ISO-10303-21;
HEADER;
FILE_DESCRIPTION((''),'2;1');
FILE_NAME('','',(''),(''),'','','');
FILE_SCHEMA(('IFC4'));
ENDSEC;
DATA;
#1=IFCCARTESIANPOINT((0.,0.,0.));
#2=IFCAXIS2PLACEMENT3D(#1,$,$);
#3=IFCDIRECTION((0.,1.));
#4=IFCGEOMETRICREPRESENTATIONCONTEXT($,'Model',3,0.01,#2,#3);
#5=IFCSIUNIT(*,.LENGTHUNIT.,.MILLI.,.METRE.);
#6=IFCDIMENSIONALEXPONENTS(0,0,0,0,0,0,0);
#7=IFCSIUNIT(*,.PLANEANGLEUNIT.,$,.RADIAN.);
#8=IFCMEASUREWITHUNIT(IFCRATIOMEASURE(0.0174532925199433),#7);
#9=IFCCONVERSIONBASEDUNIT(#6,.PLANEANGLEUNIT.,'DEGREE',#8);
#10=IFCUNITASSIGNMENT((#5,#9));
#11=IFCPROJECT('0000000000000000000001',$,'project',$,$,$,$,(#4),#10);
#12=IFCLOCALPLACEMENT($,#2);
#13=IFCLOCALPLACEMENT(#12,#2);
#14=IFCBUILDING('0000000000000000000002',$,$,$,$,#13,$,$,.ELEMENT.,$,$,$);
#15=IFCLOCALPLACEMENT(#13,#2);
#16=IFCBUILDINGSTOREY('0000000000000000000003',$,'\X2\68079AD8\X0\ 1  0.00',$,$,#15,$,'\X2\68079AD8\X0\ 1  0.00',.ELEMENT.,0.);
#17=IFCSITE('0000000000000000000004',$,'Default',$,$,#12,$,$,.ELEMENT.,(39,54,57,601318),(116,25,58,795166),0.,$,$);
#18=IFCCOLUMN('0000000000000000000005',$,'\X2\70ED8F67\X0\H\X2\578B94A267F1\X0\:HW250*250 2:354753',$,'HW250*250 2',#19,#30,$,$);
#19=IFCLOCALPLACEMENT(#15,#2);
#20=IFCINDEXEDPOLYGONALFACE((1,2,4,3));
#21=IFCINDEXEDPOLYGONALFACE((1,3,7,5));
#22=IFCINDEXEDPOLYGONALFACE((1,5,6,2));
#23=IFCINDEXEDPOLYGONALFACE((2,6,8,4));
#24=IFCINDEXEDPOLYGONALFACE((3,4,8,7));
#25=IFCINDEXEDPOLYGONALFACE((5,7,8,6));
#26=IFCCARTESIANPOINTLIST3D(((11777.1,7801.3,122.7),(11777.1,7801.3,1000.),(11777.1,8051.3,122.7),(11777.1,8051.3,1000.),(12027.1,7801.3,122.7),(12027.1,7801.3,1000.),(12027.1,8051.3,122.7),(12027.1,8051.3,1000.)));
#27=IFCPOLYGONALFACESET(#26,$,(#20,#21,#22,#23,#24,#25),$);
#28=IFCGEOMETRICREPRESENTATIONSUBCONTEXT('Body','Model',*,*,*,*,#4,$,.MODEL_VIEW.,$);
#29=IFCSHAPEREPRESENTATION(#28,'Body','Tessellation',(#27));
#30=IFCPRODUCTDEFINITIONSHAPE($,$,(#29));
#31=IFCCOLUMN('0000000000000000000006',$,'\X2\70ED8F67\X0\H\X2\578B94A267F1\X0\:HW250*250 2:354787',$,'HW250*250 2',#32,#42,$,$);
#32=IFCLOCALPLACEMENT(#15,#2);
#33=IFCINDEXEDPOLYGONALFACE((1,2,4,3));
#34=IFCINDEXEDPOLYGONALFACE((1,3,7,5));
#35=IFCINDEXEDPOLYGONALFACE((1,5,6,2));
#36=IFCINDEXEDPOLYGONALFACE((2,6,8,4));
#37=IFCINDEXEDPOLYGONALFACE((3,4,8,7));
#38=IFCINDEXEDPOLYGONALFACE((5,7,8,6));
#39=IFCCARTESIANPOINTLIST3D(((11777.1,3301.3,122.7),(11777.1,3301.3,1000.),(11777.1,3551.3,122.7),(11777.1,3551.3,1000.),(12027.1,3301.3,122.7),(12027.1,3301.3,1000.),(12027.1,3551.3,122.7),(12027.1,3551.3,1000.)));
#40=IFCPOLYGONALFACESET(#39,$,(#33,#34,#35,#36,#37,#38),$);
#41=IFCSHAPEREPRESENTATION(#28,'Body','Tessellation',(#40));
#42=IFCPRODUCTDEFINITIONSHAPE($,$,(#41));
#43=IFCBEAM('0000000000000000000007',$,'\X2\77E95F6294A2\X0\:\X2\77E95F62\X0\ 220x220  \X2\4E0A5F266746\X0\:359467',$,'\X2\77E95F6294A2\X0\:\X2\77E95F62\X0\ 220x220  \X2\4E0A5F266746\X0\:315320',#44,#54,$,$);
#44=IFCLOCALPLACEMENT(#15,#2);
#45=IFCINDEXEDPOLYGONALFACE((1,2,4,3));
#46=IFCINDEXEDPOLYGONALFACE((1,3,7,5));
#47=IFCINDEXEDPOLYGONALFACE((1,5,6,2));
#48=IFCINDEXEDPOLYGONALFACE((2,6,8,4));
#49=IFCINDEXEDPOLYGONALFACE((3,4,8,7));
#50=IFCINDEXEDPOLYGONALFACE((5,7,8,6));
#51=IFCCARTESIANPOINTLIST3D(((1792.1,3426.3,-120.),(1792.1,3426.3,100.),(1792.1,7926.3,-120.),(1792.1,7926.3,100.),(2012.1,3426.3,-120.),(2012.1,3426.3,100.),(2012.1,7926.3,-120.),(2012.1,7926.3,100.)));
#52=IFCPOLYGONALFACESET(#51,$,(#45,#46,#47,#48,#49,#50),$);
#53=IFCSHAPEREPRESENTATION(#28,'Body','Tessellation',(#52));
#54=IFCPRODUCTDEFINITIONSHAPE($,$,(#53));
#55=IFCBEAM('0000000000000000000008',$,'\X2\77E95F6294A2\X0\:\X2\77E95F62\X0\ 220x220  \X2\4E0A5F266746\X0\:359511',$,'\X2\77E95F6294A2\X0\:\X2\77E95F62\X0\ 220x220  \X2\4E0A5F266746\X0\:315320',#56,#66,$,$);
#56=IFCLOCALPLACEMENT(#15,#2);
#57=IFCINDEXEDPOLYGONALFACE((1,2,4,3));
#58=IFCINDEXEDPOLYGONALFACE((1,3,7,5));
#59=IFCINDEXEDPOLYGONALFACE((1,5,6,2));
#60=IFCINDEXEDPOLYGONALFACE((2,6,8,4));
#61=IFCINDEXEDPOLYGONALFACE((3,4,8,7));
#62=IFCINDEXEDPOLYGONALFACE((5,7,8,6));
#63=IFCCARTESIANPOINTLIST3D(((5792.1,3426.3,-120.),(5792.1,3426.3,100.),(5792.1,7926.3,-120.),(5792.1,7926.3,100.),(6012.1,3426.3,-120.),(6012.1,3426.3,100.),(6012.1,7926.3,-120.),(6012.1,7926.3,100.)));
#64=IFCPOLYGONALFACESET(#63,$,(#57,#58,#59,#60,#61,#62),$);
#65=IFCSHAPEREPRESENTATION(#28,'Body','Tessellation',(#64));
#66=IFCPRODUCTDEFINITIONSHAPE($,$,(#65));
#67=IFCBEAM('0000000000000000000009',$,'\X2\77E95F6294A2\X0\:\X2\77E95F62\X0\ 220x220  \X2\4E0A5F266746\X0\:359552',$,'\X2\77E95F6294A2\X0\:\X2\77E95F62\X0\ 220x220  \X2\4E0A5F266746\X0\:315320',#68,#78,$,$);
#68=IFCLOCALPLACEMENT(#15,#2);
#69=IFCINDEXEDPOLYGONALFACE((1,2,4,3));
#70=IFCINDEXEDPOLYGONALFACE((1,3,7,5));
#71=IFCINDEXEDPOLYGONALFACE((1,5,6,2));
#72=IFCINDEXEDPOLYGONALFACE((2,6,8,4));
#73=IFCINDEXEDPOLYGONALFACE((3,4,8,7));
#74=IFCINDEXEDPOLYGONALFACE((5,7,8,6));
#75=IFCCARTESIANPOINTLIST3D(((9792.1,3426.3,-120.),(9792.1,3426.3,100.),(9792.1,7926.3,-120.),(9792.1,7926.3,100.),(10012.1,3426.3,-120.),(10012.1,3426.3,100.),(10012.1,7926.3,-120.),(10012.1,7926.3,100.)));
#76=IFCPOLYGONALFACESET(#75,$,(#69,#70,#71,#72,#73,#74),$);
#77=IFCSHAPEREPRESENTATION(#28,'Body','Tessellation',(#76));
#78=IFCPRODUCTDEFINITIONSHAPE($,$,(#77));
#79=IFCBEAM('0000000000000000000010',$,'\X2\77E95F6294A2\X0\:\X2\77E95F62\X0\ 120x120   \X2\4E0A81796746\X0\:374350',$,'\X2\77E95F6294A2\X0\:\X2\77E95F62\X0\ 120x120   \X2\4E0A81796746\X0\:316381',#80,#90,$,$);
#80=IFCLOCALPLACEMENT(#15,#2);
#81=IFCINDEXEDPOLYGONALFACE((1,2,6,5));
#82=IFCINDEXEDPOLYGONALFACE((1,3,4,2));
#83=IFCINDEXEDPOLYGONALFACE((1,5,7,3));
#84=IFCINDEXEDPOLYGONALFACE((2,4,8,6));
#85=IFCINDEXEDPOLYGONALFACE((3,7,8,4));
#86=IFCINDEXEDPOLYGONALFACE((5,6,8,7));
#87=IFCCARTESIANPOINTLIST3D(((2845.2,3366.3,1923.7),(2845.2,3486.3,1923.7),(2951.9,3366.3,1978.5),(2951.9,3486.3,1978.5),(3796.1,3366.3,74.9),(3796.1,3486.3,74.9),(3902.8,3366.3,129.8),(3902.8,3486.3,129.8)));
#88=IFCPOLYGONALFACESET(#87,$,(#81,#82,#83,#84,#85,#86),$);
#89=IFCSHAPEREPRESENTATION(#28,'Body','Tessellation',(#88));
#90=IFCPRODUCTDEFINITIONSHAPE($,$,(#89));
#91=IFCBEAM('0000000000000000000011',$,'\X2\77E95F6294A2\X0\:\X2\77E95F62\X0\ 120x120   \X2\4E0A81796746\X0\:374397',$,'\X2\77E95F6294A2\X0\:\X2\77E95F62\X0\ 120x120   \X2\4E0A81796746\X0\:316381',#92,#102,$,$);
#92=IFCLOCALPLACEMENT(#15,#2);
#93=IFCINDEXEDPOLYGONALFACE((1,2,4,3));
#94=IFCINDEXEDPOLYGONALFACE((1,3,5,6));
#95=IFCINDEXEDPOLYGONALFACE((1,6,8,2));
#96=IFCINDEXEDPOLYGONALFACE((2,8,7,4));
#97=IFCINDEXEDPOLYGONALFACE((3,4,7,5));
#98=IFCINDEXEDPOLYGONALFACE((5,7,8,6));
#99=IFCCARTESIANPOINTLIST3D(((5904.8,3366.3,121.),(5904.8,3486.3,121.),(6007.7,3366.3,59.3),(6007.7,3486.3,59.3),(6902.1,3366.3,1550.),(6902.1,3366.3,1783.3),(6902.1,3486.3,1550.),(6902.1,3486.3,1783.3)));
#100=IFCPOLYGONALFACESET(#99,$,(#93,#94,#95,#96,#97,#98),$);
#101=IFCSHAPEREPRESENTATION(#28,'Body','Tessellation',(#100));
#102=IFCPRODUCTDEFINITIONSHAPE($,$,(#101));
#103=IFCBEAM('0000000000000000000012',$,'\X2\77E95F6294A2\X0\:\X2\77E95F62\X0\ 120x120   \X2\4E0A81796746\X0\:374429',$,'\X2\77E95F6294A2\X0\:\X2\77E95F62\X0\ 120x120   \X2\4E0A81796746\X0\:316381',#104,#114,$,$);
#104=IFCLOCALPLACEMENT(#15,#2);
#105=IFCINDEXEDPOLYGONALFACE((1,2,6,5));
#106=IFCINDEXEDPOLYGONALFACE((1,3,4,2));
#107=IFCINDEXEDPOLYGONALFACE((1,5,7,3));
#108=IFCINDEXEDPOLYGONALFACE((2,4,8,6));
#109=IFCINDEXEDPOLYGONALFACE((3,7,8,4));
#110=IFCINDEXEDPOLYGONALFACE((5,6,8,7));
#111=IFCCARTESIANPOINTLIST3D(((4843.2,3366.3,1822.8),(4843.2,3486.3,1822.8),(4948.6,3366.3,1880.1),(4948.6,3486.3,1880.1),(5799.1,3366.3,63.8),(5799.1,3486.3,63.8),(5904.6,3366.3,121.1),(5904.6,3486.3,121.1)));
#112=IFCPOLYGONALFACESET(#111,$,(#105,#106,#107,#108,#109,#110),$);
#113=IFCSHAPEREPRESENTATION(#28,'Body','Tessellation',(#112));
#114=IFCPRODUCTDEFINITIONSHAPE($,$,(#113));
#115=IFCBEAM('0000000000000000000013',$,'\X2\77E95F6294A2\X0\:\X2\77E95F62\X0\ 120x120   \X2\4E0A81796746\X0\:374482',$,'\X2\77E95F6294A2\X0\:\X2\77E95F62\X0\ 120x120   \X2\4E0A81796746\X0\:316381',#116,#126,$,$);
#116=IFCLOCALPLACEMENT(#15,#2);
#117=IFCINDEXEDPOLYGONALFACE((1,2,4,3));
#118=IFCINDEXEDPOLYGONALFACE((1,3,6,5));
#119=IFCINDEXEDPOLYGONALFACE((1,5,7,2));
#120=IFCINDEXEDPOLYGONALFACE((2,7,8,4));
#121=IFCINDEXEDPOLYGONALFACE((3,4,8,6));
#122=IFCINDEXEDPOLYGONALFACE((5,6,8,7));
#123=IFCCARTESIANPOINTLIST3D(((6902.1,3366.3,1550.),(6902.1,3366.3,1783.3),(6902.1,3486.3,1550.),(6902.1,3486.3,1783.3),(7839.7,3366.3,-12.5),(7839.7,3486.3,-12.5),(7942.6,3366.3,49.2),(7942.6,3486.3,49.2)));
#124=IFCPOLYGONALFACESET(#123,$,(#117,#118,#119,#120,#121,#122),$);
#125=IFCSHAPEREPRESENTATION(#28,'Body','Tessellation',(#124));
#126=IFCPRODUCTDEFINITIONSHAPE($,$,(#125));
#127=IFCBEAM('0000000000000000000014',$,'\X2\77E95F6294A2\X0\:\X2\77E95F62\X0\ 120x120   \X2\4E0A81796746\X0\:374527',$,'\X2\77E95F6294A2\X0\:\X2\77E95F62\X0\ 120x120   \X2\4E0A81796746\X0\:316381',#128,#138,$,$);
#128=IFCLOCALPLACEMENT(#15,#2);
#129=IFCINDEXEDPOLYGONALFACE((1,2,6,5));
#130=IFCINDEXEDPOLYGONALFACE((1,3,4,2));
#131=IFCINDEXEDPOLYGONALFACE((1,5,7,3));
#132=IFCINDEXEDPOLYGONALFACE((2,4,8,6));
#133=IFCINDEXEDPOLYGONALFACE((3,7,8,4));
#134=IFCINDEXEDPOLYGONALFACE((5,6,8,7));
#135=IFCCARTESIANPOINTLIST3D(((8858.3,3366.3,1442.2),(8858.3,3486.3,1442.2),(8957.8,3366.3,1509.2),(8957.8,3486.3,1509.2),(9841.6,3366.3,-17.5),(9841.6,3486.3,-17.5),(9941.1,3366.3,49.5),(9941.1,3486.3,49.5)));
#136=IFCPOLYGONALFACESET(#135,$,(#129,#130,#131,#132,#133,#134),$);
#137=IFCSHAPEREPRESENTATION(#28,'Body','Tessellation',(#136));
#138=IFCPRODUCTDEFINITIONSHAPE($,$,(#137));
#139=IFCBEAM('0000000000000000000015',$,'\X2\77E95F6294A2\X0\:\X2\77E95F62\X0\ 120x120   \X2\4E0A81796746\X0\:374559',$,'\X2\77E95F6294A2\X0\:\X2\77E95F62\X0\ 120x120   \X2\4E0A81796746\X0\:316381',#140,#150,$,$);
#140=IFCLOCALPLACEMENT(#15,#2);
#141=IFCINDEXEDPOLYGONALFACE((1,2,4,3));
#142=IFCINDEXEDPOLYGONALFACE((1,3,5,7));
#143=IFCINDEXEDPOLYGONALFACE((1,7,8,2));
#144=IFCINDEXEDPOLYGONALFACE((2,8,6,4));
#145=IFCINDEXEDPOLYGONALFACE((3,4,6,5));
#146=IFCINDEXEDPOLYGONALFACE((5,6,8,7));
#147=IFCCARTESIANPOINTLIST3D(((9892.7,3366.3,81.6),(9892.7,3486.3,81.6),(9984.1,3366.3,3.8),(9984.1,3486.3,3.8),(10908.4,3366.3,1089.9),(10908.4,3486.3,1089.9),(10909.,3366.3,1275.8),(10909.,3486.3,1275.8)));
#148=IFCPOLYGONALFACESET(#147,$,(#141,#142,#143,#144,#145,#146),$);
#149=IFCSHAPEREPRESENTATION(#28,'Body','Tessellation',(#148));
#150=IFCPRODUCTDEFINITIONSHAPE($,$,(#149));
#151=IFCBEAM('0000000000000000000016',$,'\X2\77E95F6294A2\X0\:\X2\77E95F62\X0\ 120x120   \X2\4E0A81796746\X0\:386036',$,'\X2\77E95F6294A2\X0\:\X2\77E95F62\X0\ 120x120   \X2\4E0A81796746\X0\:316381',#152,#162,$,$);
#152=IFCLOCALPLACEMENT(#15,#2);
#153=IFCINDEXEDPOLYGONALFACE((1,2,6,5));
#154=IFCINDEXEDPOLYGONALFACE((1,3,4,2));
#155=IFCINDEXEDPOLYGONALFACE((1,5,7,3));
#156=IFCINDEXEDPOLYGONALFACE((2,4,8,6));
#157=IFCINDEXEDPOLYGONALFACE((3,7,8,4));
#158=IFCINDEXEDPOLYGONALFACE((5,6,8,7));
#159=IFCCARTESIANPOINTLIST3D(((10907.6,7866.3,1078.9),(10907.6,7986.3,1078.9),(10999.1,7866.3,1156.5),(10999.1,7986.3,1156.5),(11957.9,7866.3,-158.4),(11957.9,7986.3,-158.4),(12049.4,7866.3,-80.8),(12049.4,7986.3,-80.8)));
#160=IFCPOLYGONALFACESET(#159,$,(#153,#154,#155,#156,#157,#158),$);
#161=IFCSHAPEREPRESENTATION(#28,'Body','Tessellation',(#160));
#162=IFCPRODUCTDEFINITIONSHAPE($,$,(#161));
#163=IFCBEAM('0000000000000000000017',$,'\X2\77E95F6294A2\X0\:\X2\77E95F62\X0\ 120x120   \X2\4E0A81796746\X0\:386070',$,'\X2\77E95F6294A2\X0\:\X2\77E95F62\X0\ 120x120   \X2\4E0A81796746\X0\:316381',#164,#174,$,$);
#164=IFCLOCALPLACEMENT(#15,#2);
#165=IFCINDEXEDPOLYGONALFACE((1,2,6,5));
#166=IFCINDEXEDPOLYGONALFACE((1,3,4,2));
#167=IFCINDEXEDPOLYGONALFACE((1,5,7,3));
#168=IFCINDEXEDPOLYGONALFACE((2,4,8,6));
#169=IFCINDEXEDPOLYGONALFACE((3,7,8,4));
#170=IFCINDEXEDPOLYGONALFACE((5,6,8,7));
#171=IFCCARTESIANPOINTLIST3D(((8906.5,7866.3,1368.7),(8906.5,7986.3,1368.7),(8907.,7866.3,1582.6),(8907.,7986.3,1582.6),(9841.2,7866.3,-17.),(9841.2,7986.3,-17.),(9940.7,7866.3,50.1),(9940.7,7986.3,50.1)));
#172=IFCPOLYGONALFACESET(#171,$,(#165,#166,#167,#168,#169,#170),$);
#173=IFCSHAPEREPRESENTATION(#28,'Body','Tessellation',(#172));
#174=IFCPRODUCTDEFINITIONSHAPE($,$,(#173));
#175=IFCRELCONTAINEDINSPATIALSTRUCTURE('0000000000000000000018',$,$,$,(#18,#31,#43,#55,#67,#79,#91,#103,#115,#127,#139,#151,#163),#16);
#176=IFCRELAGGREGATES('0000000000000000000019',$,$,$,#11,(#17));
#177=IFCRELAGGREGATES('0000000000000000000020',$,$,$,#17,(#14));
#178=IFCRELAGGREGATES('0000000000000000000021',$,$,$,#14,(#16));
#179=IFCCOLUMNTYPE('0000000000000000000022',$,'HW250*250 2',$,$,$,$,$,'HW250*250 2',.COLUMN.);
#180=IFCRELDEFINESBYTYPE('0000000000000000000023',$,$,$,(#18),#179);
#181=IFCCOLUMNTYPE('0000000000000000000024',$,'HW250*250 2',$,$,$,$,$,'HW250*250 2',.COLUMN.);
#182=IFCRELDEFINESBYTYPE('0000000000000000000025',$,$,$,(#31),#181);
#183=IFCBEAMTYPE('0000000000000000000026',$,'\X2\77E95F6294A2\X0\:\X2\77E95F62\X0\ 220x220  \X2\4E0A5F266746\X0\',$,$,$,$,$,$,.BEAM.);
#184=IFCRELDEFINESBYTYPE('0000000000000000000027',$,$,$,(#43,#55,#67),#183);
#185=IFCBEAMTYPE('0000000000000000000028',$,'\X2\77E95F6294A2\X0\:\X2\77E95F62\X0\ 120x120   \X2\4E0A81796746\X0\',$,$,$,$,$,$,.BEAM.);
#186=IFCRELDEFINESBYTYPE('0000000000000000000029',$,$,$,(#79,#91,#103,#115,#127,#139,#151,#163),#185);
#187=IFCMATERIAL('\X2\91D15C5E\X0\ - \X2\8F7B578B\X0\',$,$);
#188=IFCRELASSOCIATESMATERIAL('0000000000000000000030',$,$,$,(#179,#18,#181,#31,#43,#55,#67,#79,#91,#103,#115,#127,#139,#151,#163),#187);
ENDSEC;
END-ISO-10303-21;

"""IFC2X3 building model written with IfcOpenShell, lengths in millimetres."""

from ifc_helpers import new_model, entity, si_unit, converted_unit, direction, frame, frame_2d, origin, origin_2d_with_axis, place, context, subcontext, project, spatial, rectangle, extrude, clip, halfspace, source, transform, mapped, material, type_object, type_shapes, element, save


model = new_model("IFC2X3")

# Units and contexts
model_context = context("Model", 3, precision=0.01, world=origin(), true_north=direction((0.0, 1.0)))
body_context = subcontext(model_context, "Body", "Model", "MODEL_VIEW")
ifc_project = project(units=[si_unit("LENGTHUNIT", "METRE", prefix="MILLI"), converted_unit("PLANEANGLEUNIT", "DEGREE", entity("IfcRatioMeasure", 0.0174532925199433), si_unit("PLANEANGLEUNIT", "RADIAN"), dimensions=[0, 0, 0, 0, 0, 0, 0])], contexts=[model_context])

# Site, building, storey
site_placement = place(None, origin())
site = spatial("IfcSite", under=ifc_project, at=site_placement, Name="Default", CompositionType="ELEMENT", RefLatitude=(39, 54, 57, 601318), RefLongitude=(116, 25, 58, 795166), RefElevation=0.0)
building_placement = place(site_placement, origin())
building = spatial("IfcBuilding", under=site, at=building_placement, CompositionType="ELEMENT")
storey_placement = place(building_placement, origin())
storey = spatial("IfcBuildingStorey", under=building, at=storey_placement, Name="标高 1  0.00", LongName="标高 1  0.00", CompositionType="ELEMENT", Elevation=0.0)

# Columns
ifc_material_1 = material(Name="金属 - 轻型")
column_type_1 = type_object("IfcColumnType", Name="HW250*250 2", ElementType="HW250*250 2", PredefinedType="COLUMN", material=ifc_material_1)
shared_shape_1 = source(origin(), body_context, "Body", "SweptSolid", [
    extrude(rectangle(XDim=250.0, YDim=250.0, at=origin_2d_with_axis()), frame((11902.1, 7926.3, 122.7), z_axis=(0.0, 0.0, 1.0), x_axis=(0.0, -1.0, 0.0)), (0.0, 0.0, 1.0), 877.3),
])
type_shapes(column_type_1, [shared_shape_1])
column_1_placement = place(storey_placement, origin())
element("IfcColumn", 1, at=column_1_placement, inside=storey, type_object=column_type_1, material=ifc_material_1, Name="热轧H型钢柱:HW250*250 2:354753", ObjectType="HW250*250 2", context=body_context, shape_type="MappedRepresentation", body=[
    mapped(shared_shape_1, transform((0.0, 0.0, 0.0), scale=1.0)),
])
column_type_2 = type_object("IfcColumnType", Name="HW250*250 2", ElementType="HW250*250 2", PredefinedType="COLUMN", material=ifc_material_1)
shared_shape_2 = source(origin(), body_context, "Body", "SweptSolid", [
    extrude(rectangle(XDim=250.0, YDim=250.0, at=frame_2d((0.0, 0.0), x_axis=(1.0, 0.0))), frame((11902.1, 3426.3, 122.7), z_axis=(0.0, 0.0, 1.0), x_axis=(0.0, -1.0, 0.0)), (0.0, 0.0, 1.0), 877.3),
])
type_shapes(column_type_2, [shared_shape_2])
column_2_placement = place(storey_placement, origin())
element("IfcColumn", 2, at=column_2_placement, inside=storey, type_object=column_type_2, material=ifc_material_1, Name="热轧H型钢柱:HW250*250 2:354787", ObjectType="HW250*250 2", context=body_context, shape_type="MappedRepresentation", body=[
    mapped(shared_shape_2, transform((0.0, 0.0, 0.0), scale=1.0)),
])

# Beams
beam_type_1 = type_object("IfcBeamType", Name="矩形钢:矩形 220x220  上弦杆", PredefinedType="BEAM")
beam_1_placement = place(storey_placement, frame((1902.1, 7926.3, -10.0), z_axis=(0.0, 0.0, 1.0), x_axis=(0.0, -1.0, 0.0)))
element("IfcBeam", 3, at=beam_1_placement, inside=storey, type_object=beam_type_1, material=ifc_material_1, Name="矩形钢:矩形 220x220  上弦杆:359467", ObjectType="矩形钢:矩形 220x220  上弦杆:315320", context=body_context, shape_type="SweptSolid", body=[
    extrude(rectangle(XDim=220.0, YDim=220.0, at=origin_2d_with_axis()), frame((0.0, 0.0, 0.0), z_axis=(1.0, 0.0, 0.0), x_axis=(0.0, 0.0, -1.0)), (0.0, 0.0, 1.0), 4500.0),
])
beam_2_placement = place(storey_placement, frame((5902.1, 7926.3, -10.0), z_axis=(0.0, 0.0, 1.0), x_axis=(0.0, -1.0, 0.0)))
element("IfcBeam", 4, at=beam_2_placement, inside=storey, type_object=beam_type_1, material=ifc_material_1, Name="矩形钢:矩形 220x220  上弦杆:359511", ObjectType="矩形钢:矩形 220x220  上弦杆:315320", context=body_context, shape_type="SweptSolid", body=[
    extrude(rectangle(XDim=220.0, YDim=220.0, at=frame_2d((0.0, 0.0), x_axis=(1.0, 0.0))), frame((0.0, 0.0, 0.0), z_axis=(1.0, 0.0, 0.0), x_axis=(0.0, 0.0, -1.0)), (0.0, 0.0, 1.0), 4500.0),
])
beam_3_placement = place(storey_placement, frame((9902.1, 7926.3, -10.0), z_axis=(0.0, 0.0, 1.0), x_axis=(0.0, -1.0, 0.0)))
element("IfcBeam", 5, at=beam_3_placement, inside=storey, type_object=beam_type_1, material=ifc_material_1, Name="矩形钢:矩形 220x220  上弦杆:359552", ObjectType="矩形钢:矩形 220x220  上弦杆:315320", context=body_context, shape_type="SweptSolid", body=[
    extrude(rectangle(XDim=220.0, YDim=220.0, at=frame_2d((0.0, 0.0), x_axis=(1.0, 0.0))), frame((0.0, 0.0, 0.0), z_axis=(1.0, 0.0, 0.0), x_axis=(0.0, 0.0, -1.0)), (0.0, 0.0, 1.0), 4500.0),
])
beam_type_2 = type_object("IfcBeamType", Name="矩形钢:矩形 120x120   上腹杆", PredefinedType="BEAM")
beam_4_placement = place(storey_placement, frame((3902.1, 3426.3, 0.0), z_axis=(0.889261, 0.0, 0.457401), x_axis=(-0.457401, 0.0, 0.889261)))
element("IfcBeam", 6, at=beam_4_placement, inside=storey, type_object=beam_type_2, material=ifc_material_1, Name="矩形钢:矩形 120x120   上腹杆:374350", ObjectType="矩形钢:矩形 120x120   上腹杆:316381", context=body_context, shape_type="SweptSolid", body=[
    extrude(rectangle(XDim=120.0, YDim=120.0, at=frame_2d((0.0, 0.0), x_axis=(1.0, 0.0))), frame((115.1, 0.0, 0.0), z_axis=(1.0, 0.0, 0.0), x_axis=(0.0, 0.0, -1.0)), (0.0, 0.0, 1.0), 2079.0),
])
beam_5_placement = place(storey_placement, frame((5902.1, 3426.3, 0.0), z_axis=(0.857493, 0.0, -0.514496), x_axis=(0.514496, 0.0, 0.857493)))
element("IfcBeam", 7, at=beam_5_placement, inside=storey, type_object=beam_type_2, material=ifc_material_1, Name="矩形钢:矩形 120x120   上腹杆:374397", ObjectType="矩形钢:矩形 120x120   上腹杆:316381", context=body_context, shape_type="Clipping", body=[
    clip(extrude(rectangle(XDim=120.0, YDim=120.0, at=frame_2d((0.0, 0.0), x_axis=(1.0, 0.0))), frame((105.2, 0.0, 0.0), z_axis=(1.0, 0.0, 0.0), x_axis=(0.0, 0.0, -1.0)), (0.0, 0.0, 1.0), 1938.5), halfspace(frame((1843.7, 0.0, 60.0), z_axis=(0.514496, 0.0, 0.857493), x_axis=(0.0, 1.0, 0.0)), False)),
])
beam_6_placement = place(storey_placement, frame((5902.1, 3426.3, 0.0), z_axis=(0.87863, 0.0, 0.477502), x_axis=(-0.477502, 0.0, 0.87863)))
element("IfcBeam", 8, at=beam_6_placement, inside=storey, type_object=beam_type_2, material=ifc_material_1, Name="矩形钢:矩形 120x120   上腹杆:374429", ObjectType="矩形钢:矩形 120x120   上腹杆:316381", context=body_context, shape_type="SweptSolid", body=[
    extrude(rectangle(XDim=120.0, YDim=120.0, at=frame_2d((0.0, 0.0), x_axis=(1.0, 0.0))), frame((105.3, 0.0, 0.0), z_axis=(1.0, 0.0, 0.0), x_axis=(0.0, 0.0, -1.0)), (0.0, 0.0, 1.0), 2002.0),
])
beam_7_placement = place(storey_placement, frame((7902.1, 3426.3, 0.0), z_axis=(0.857493, 0.0, 0.514496), x_axis=(-0.514496, 0.0, 0.857493)))
element("IfcBeam", 9, at=beam_7_placement, inside=storey, type_object=beam_type_2, material=ifc_material_1, Name="矩形钢:矩形 120x120   上腹杆:374482", ObjectType="矩形钢:矩形 120x120   上腹杆:316381", context=body_context, shape_type="Clipping", body=[
    clip(extrude(rectangle(XDim=120.0, YDim=120.0, at=frame_2d((0.0, 0.0), x_axis=(1.0, 0.0))), frame((21.4, 0.0, 0.0), z_axis=(1.0, 0.0, 0.0), x_axis=(0.0, 0.0, -1.0)), (0.0, 0.0, 1.0), 2022.3), halfspace(frame((1843.7, 0.0, -60.0), z_axis=(0.514496, 0.0, -0.857493), x_axis=(0.0, -1.0, 0.0)), False)),
])
beam_8_placement = place(storey_placement, frame((9902.1, 3426.3, 0.0), z_axis=(0.829376, 0.0, 0.55869), x_axis=(-0.55869, 0.0, 0.829376)))
element("IfcBeam", 10, at=beam_8_placement, inside=storey, type_object=beam_type_2, material=ifc_material_1, Name="矩形钢:矩形 120x120   上腹杆:374527", ObjectType="矩形钢:矩形 120x120   上腹杆:316381", context=body_context, shape_type="SweptSolid", body=[
    extrude(rectangle(XDim=120.0, YDim=120.0, at=origin_2d_with_axis()), frame((19.3, 0.0, 0.0), z_axis=(1.0, 0.0, 0.0), x_axis=(0.0, 0.0, -1.0)), (0.0, 0.0, 1.0), 1760.0),
])
beam_9_placement = place(storey_placement, frame((10908.6, 3426.3, 1182.8), z_axis=(0.761584, 0.0, -0.648066), x_axis=(-0.648066, 0.0, -0.761584)))
element("IfcBeam", 11, at=beam_9_placement, inside=storey, type_object=beam_type_2, material=ifc_material_1, Name="矩形钢:矩形 120x120   上腹杆:374559", ObjectType="矩形钢:矩形 120x120   上腹杆:316381", context=body_context, shape_type="Clipping", body=[
    clip(extrude(rectangle(XDim=120.0, YDim=120.0, at=frame_2d((0.0, 0.0), x_axis=(1.0, 0.0))), frame((-71.1, 0.0, 0.0), z_axis=(1.0, 0.0, 0.0), x_axis=(0.0, 0.0, -1.0)), (0.0, 0.0, 1.0), 1568.1), halfspace(frame((-71.1, 0.0, -60.0), z_axis=(-0.645598, 0.0, 0.763678), x_axis=(-0.763678, 0.0, -0.645598)), False)),
])
beam_10_placement = place(storey_placement, frame((11902.1, 7926.3, 0.0), z_axis=(0.762354, 0.0, 0.64716), x_axis=(-0.64716, 0.0, 0.762354)))
element("IfcBeam", 12, at=beam_10_placement, inside=storey, type_object=beam_type_2, material=ifc_material_1, Name="矩形钢:矩形 120x120   上腹杆:386036", ObjectType="矩形钢:矩形 120x120   上腹杆:316381", context=body_context, shape_type="SweptSolid", body=[
    extrude(rectangle(XDim=120.0, YDim=120.0, at=frame_2d((0.0, 0.0), x_axis=(1.0, 0.0))), frame((-156.9, 0.0, 0.0), z_axis=(1.0, 0.0, 0.0), x_axis=(0.0, 0.0, -1.0)), (0.0, 0.0, 1.0), 1623.0),
])
beam_11_placement = place(storey_placement, frame((9902.1, 7926.3, 0.0), z_axis=(0.829038, 0.0, 0.559193), x_axis=(-0.559193, 0.0, 0.829038)))
element("IfcBeam", 13, at=beam_11_placement, inside=storey, type_object=beam_type_2, material=ifc_material_1, Name="矩形钢:矩形 120x120   上腹杆:386070", ObjectType="矩形钢:矩形 120x120   上腹杆:316381", context=body_context, shape_type="Clipping", body=[
    clip(extrude(rectangle(XDim=120.0, YDim=120.0, at=origin_2d_with_axis()), frame((20.0, 0.0, 0.0), z_axis=(1.0, 0.0, 0.0), x_axis=(0.0, 0.0, -1.0)), (0.0, 0.0, 1.0), 1848.5), halfspace(frame((1691.5, 0.0, -60.0), z_axis=(0.560977, 0.0, -0.827832), x_axis=(0.827832, 0.0, 0.560977)), False)),
])

save(model, "model.ifc")
